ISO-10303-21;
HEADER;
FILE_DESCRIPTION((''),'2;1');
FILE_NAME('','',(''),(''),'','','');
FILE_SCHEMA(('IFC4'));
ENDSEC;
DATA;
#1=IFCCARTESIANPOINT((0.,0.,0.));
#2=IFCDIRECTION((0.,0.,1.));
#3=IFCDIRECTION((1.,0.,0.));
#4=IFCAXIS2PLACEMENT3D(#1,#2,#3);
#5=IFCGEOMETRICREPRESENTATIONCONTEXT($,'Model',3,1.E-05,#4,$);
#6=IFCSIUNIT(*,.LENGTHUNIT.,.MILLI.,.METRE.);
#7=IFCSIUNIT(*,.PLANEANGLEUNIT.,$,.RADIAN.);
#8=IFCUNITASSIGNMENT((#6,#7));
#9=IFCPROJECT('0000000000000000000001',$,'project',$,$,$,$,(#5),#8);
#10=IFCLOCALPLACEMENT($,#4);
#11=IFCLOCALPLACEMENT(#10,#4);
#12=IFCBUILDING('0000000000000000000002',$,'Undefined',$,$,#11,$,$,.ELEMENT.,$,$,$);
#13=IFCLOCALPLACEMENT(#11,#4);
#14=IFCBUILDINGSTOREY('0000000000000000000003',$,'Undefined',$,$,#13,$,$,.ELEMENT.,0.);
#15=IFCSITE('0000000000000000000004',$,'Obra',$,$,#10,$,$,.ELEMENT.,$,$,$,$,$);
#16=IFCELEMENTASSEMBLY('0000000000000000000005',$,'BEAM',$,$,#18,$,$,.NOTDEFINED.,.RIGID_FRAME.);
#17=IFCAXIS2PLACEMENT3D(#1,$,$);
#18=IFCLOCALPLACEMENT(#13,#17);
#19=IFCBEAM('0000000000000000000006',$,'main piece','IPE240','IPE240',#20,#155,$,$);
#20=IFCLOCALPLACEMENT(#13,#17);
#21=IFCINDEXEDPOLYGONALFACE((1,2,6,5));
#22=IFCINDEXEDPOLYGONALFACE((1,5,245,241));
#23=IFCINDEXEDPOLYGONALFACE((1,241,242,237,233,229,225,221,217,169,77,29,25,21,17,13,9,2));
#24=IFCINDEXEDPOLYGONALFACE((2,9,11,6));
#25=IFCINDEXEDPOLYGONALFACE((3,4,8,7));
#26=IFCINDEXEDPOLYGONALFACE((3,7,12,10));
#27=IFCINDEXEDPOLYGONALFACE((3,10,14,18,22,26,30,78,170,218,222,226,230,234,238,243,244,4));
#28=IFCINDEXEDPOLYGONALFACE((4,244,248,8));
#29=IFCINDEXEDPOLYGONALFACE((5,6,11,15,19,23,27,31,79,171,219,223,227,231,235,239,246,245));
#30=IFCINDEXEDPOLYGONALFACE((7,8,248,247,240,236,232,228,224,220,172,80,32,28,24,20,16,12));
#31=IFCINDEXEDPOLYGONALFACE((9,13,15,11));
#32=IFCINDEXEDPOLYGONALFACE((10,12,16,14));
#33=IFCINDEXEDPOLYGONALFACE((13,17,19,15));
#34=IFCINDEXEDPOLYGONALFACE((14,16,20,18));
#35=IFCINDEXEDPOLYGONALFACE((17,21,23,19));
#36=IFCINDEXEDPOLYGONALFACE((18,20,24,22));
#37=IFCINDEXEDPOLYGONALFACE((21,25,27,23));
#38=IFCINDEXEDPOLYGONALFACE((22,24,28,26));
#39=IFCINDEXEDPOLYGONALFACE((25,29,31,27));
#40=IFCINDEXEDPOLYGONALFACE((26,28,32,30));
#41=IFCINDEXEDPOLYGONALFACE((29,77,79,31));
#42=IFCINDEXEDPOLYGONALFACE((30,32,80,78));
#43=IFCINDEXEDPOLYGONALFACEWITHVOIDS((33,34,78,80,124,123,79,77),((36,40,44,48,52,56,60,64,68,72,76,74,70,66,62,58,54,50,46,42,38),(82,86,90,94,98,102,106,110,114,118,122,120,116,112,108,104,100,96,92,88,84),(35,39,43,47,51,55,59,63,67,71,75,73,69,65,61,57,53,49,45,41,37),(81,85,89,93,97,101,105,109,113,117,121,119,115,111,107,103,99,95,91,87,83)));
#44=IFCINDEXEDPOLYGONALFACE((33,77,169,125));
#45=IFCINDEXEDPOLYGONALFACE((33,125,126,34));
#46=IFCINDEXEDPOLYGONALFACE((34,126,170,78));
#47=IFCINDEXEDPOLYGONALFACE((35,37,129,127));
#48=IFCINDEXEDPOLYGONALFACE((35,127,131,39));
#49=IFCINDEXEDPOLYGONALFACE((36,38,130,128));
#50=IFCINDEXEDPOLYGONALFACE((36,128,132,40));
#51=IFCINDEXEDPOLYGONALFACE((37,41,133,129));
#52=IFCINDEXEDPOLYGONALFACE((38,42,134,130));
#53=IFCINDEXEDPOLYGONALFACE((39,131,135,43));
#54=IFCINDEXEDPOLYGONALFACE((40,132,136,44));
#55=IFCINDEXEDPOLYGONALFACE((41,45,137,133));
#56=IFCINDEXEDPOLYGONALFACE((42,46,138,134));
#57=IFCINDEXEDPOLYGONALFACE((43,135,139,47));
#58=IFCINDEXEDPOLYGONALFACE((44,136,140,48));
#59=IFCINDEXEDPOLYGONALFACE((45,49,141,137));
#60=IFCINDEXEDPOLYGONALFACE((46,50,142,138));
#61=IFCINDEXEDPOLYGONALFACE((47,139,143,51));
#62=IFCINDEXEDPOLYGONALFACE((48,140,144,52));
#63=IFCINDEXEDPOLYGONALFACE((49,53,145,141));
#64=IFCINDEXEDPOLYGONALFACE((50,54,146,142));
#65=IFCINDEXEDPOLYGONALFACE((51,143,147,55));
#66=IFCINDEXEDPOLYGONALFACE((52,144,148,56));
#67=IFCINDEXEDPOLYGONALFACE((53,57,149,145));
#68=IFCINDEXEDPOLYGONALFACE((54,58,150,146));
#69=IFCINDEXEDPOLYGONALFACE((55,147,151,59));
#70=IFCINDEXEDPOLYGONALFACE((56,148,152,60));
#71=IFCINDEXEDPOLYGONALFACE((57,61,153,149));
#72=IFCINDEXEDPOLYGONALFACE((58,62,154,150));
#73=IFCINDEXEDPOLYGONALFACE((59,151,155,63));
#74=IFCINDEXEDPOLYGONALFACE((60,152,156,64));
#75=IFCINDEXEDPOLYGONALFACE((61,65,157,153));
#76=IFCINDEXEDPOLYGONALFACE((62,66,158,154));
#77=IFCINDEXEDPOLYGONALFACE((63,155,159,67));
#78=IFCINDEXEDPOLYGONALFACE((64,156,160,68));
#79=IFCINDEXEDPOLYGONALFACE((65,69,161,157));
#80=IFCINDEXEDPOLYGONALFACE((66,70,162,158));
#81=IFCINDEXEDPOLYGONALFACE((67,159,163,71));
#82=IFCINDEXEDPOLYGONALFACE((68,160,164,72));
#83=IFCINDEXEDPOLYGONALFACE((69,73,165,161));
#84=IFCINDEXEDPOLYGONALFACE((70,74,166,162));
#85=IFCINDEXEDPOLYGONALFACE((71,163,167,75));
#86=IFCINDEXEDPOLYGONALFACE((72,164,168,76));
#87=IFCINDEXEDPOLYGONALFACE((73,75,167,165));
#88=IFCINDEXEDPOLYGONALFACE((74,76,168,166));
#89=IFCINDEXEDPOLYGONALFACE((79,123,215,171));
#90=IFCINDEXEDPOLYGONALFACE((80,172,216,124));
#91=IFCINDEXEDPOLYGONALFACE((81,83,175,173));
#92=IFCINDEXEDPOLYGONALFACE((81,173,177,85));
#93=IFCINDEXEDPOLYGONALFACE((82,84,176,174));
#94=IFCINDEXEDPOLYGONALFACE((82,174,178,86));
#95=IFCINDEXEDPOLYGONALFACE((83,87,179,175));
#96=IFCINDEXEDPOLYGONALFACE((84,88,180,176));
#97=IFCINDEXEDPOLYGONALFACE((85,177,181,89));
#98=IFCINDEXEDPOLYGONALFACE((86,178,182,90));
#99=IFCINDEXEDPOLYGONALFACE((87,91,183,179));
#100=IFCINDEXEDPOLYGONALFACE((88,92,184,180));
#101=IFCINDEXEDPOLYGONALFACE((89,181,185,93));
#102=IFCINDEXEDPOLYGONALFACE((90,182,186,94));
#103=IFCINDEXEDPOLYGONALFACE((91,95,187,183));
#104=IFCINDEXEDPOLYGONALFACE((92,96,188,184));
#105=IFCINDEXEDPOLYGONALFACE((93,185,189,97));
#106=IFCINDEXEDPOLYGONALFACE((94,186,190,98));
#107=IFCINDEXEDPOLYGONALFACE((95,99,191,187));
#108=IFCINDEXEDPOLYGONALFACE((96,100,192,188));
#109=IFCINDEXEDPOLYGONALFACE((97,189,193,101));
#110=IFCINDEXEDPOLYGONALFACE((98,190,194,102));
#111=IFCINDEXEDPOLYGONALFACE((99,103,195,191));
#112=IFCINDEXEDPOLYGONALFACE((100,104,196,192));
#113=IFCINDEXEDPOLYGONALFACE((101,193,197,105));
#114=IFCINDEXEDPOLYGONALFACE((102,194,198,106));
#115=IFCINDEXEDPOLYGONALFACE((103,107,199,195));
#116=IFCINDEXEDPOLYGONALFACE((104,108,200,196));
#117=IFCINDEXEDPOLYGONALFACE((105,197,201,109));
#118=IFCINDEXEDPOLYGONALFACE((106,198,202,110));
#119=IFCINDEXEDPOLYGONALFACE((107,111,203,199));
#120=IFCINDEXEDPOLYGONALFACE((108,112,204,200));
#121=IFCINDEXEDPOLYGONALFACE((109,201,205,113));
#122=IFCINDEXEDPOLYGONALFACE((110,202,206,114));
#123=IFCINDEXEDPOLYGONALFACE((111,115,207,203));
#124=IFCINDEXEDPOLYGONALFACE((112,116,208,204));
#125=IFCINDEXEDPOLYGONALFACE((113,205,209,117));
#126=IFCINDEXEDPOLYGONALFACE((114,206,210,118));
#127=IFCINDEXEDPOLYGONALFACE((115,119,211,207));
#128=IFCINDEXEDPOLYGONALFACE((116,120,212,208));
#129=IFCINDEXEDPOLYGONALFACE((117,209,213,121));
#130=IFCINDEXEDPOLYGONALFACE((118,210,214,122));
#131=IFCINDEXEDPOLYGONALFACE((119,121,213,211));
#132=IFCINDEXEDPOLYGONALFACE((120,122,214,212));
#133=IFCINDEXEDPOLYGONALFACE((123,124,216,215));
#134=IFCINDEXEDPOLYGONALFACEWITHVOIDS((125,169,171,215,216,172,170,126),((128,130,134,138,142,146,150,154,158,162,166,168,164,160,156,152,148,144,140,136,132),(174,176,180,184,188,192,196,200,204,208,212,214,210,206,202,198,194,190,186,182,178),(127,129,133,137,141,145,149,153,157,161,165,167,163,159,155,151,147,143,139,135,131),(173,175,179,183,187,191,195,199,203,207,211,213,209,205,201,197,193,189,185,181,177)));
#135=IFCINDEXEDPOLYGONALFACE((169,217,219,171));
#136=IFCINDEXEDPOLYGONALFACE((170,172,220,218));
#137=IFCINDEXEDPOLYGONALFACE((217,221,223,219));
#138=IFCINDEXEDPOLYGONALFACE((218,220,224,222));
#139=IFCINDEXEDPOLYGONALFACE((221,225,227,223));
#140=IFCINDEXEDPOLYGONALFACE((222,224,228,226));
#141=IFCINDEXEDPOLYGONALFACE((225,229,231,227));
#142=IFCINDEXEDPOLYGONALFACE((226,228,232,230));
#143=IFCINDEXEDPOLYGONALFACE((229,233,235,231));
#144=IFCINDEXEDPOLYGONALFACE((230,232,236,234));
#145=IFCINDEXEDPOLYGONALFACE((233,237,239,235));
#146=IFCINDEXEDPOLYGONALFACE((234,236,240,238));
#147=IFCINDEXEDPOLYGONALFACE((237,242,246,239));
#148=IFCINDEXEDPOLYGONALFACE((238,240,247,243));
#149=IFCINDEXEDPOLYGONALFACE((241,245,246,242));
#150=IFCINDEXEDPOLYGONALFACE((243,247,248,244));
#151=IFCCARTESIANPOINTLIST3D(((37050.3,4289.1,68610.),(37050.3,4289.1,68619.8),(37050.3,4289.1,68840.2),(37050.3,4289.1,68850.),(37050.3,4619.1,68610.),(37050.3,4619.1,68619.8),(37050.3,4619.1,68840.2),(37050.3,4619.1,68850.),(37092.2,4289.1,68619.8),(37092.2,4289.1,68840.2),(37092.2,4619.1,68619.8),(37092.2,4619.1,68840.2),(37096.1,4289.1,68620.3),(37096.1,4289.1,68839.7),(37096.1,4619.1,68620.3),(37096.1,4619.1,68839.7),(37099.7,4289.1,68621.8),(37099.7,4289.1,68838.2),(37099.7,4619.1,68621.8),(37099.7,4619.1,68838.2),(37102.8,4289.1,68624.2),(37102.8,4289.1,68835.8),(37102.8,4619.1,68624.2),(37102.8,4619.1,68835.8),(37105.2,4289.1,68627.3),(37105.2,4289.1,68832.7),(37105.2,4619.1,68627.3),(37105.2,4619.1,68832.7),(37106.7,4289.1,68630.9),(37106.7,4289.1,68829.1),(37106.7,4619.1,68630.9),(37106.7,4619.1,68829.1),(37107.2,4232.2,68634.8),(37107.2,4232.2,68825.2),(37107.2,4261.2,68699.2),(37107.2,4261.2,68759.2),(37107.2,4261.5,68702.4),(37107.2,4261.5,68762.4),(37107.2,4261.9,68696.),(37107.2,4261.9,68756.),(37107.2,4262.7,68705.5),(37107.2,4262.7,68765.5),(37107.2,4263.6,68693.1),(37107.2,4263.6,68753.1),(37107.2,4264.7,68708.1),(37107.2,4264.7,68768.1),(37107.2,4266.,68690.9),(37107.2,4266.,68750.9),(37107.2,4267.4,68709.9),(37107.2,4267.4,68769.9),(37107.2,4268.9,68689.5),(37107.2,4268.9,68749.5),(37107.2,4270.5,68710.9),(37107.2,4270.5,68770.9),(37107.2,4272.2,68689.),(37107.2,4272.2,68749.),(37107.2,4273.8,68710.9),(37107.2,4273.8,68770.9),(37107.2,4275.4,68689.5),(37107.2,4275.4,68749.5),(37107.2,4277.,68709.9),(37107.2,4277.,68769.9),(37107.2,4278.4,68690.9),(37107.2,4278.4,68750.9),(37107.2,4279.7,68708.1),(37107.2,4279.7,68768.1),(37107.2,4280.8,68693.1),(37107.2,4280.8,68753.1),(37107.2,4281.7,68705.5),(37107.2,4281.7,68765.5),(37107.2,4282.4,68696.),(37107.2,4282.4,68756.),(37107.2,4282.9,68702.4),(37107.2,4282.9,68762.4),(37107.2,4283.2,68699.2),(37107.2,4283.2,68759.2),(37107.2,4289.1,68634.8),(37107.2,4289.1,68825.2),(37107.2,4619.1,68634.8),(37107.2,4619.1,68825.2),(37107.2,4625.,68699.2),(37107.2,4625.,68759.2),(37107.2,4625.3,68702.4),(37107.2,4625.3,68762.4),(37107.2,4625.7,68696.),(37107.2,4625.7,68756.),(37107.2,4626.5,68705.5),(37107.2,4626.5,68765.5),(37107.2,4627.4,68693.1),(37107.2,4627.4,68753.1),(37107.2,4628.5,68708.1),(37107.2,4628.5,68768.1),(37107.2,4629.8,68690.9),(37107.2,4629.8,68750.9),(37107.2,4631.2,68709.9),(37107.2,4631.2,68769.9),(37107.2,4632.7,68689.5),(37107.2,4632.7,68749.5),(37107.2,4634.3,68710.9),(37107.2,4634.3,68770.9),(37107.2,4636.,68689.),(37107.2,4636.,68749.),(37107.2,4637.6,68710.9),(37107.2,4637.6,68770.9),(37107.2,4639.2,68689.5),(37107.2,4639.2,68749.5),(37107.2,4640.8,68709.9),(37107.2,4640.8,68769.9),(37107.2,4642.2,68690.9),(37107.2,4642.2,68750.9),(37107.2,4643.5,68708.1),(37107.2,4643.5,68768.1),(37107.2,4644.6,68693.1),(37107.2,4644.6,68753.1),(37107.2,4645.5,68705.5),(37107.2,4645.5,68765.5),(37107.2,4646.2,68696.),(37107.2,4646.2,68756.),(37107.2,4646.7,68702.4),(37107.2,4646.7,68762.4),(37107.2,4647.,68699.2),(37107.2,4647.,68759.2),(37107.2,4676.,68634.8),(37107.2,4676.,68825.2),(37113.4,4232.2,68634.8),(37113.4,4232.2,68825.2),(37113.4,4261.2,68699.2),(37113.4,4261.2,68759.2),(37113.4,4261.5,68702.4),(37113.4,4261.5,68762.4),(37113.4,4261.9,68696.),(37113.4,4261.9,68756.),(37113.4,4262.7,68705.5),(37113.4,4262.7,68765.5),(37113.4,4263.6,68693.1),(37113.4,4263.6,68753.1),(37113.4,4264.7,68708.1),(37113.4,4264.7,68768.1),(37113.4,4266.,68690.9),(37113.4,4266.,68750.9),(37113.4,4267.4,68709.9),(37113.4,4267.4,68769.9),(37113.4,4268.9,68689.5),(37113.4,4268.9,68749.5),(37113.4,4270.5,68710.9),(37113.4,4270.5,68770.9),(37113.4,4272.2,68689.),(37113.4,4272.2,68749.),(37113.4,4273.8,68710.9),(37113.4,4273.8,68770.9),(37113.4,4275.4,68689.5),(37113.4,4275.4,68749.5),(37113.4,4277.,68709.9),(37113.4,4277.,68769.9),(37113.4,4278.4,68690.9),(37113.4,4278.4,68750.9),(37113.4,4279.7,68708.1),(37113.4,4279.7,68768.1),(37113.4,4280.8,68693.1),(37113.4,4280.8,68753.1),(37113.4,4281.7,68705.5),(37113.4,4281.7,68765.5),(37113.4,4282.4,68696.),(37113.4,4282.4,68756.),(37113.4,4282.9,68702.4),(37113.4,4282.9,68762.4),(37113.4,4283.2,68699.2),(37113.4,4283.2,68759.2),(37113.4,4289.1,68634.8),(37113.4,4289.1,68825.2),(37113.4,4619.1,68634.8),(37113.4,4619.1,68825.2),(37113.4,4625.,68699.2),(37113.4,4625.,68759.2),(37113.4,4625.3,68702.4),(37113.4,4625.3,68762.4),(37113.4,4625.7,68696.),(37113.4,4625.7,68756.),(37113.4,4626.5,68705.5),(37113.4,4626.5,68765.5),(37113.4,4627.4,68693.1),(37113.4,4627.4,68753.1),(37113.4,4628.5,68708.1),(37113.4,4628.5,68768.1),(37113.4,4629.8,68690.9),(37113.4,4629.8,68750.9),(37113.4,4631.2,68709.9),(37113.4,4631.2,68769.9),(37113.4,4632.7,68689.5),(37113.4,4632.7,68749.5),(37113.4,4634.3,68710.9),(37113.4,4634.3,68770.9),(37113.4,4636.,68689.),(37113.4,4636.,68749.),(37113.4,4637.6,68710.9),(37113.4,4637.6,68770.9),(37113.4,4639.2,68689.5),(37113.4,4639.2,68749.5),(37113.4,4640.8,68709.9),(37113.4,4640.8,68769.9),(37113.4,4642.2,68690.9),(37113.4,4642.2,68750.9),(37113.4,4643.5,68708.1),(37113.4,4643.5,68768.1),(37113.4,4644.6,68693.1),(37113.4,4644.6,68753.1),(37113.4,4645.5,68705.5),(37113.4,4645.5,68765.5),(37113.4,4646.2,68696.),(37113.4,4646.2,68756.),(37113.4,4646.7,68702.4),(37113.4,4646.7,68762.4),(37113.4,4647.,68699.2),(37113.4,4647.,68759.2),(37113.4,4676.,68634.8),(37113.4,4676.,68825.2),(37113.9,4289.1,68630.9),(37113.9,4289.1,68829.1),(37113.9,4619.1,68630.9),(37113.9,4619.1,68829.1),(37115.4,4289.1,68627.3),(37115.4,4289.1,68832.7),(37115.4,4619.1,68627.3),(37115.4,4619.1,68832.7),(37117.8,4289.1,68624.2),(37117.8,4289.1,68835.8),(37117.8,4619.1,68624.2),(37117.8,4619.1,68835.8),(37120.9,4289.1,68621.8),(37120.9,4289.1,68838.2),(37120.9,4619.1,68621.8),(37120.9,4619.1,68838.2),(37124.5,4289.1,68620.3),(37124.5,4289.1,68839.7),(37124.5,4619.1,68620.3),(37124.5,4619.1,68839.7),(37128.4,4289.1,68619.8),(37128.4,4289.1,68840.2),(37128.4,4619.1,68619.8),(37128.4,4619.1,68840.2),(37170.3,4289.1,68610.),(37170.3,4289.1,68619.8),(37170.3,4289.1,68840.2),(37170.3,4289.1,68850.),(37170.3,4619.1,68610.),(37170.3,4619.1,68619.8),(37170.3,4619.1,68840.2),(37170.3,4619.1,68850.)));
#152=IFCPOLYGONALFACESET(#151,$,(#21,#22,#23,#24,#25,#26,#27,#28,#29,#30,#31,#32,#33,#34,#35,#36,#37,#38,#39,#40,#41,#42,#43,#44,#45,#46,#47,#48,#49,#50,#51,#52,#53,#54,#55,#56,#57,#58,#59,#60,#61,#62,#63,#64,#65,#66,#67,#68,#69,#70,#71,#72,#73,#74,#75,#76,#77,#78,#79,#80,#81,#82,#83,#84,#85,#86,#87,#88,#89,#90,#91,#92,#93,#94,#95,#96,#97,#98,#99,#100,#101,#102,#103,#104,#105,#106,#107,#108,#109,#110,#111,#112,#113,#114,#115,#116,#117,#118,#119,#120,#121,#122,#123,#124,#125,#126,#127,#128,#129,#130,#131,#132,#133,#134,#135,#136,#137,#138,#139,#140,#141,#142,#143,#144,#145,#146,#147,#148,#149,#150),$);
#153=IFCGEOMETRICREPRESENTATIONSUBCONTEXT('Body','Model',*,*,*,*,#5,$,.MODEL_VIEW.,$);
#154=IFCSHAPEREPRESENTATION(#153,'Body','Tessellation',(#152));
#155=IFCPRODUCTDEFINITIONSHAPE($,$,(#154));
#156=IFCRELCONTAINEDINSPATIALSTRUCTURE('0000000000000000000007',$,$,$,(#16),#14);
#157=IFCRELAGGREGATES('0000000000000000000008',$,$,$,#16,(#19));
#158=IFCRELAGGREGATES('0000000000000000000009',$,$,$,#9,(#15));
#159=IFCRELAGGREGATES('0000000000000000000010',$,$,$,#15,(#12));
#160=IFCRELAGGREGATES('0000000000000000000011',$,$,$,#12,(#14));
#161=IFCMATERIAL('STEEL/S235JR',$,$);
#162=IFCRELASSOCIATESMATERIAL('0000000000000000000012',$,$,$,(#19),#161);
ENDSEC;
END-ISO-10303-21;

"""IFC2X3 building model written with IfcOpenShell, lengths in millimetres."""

from ifc_helpers import new_model, si_unit, frame, origin_with_axes, origin_2d_with_axis, place, context, subcontext, project, spatial, rectangle, circle, i_section, extrude, clip, halfspace, source, transform, mapped, material, element, aggregate, save


model = new_model("IFC2X3")

# Units and contexts
model_context = context("Model", 3, precision=1e-05, world=origin_with_axes())
body_context = subcontext(model_context, "Body", "Model", "MODEL_VIEW")
ifc_project = project(units=[si_unit("LENGTHUNIT", "METRE", prefix="MILLI"), si_unit("PLANEANGLEUNIT", "RADIAN")], contexts=[model_context])

# Site, building, storey
site_placement = place(None, origin_with_axes())
site = spatial("IfcSite", under=ifc_project, at=site_placement, Name="Obra", CompositionType="ELEMENT")
building_placement = place(site_placement, origin_with_axes())
building = spatial("IfcBuilding", under=site, at=building_placement, Name="Undefined", CompositionType="ELEMENT")
storey_placement = place(building_placement, origin_with_axes())
storey = spatial("IfcBuildingStorey", under=building, at=storey_placement, Name="Undefined", CompositionType="ELEMENT", Elevation=0.0)

# Element assembly, beam, openings
assembly_1_placement = place(storey_placement, origin_with_axes())
assembly_1 = element("IfcElementAssembly", 1, at=assembly_1_placement, inside=storey, Name="BEAM", AssemblyPlace="NOTDEFINED", PredefinedType="RIGID_FRAME")
ifc_material_1 = material(Name="STEEL/S235JR")
beam_1_placement = place(assembly_1_placement, frame((37110.3, 4299.1, 68730.0), z_axis=(0.0, 0.0, 1.0), x_axis=(0.0, 1.0, 0.0)))
beam_1 = element("IfcBeam", 2, at=beam_1_placement, material=ifc_material_1, Name="main piece", Description="IPE240", ObjectType="IPE240", context=body_context, shape_type="Clipping", body=[
    clip(clip(extrude(i_section(OverallWidth=120.0, OverallDepth=240.0, WebThickness=6.2, FlangeThickness=9.8, FilletRadius=15.0, at=origin_2d_with_axis()), frame((376.9, 0.0, 0.0), z_axis=(-1.0, 0.0, 0.0), x_axis=(0.0, -1.0, 0.0)), (0.0, 0.0, 1.0), 443.8), halfspace(frame((376.9, 0.0, -220.0), z_axis=(-1.0, 0.0, 0.0), x_axis=(0.0, 1.0, 0.0)), True)), halfspace(frame((-66.9, 0.0, -220.0), z_axis=(1.0, 0.0, 0.0), x_axis=(0.0, -1.0, 0.0)), True)),
])
opening_1_placement = place(assembly_1_placement, frame((37110.3, 4299.1, 68730.0), z_axis=(0.0, 0.0, 1.0), x_axis=(0.0, 1.0, 0.0)))
element("IfcOpeningElement", 3, at=opening_1_placement, cuts=beam_1, ObjectType="Recess", context=body_context, shape_type="SweptSolid", body=[
    extrude(rectangle(XDim=25.8, YDim=68.9, at=origin_2d_with_axis()), frame((354.4, 61.0, -108.1), z_axis=(0.0, -1.0, 0.0), x_axis=(0.0, 0.0, -1.0)), (0.0, 0.0, 1.0), 122.0),
])
opening_2_placement = place(assembly_1_placement, frame((37110.3, 4299.1, 68730.0), z_axis=(0.0, 0.0, 1.0), x_axis=(0.0, 1.0, 0.0)))
element("IfcOpeningElement", 4, at=opening_2_placement, cuts=beam_1, ObjectType="Recess", context=body_context, shape_type="SweptSolid", body=[
    extrude(rectangle(XDim=25.8, YDim=68.9, at=origin_2d_with_axis()), frame((354.4, 61.0, 108.1), z_axis=(0.0, -1.0, 0.0), x_axis=(0.0, 0.0, -1.0)), (0.0, 0.0, 1.0), 122.0),
])
opening_3_placement = place(assembly_1_placement, frame((37110.3, 4299.1, 68730.0), z_axis=(0.0, 0.0, 1.0), x_axis=(0.0, 1.0, 0.0)))
element("IfcOpeningElement", 5, at=opening_3_placement, cuts=beam_1, ObjectType="Recess", context=body_context, shape_type="SweptSolid", body=[
    extrude(rectangle(XDim=25.8, YDim=68.9, at=origin_2d_with_axis()), frame((-44.4, -61.0, -108.1), z_axis=(0.0, 1.0, 0.0), x_axis=(0.0, 0.0, -1.0)), (0.0, 0.0, 1.0), 122.0),
])
opening_4_placement = place(assembly_1_placement, frame((37110.3, 4299.1, 68730.0), z_axis=(0.0, 0.0, 1.0), x_axis=(0.0, 1.0, 0.0)))
element("IfcOpeningElement", 6, at=opening_4_placement, cuts=beam_1, ObjectType="Recess", context=body_context, shape_type="SweptSolid", body=[
    extrude(rectangle(XDim=25.8, YDim=68.9, at=origin_2d_with_axis()), frame((-44.4, -61.0, 108.1), z_axis=(0.0, 1.0, 0.0), x_axis=(0.0, 0.0, -1.0)), (0.0, 0.0, 1.0), 122.0),
])
shared_shape_1 = source(origin_with_axes(), body_context, "Body", "SweptSolid", [
    extrude(circle(Radius=11.0, at=origin_2d_with_axis()), frame((0.0, -3.2, 0.0), z_axis=(0.0, 1.0, 0.0), x_axis=(1.0, 0.0, 0.0)), (0.0, 0.0, 1.0), 6.4),
])
opening_5_placement = place(assembly_1_placement, frame((37110.3, 4676.0, 68850.0), z_axis=(0.0, -1.0, 0.0), x_axis=(0.0, 0.0, -1.0)))
element("IfcOpeningElement", 7, at=opening_5_placement, cuts=beam_1, ObjectType="Opening", context=body_context, shape_type="MappedRepresentation", body=[
    mapped(shared_shape_1, transform((90.0, 0.0, 40.0))),
    mapped(shared_shape_1, transform((150.0, 0.0, 40.0))),
])
opening_6_placement = place(assembly_1_placement, frame((37110.3, 4232.2, 68850.0), z_axis=(0.0, 1.0, 0.0), x_axis=(0.0, 0.0, -1.0)))
element("IfcOpeningElement", 8, at=opening_6_placement, cuts=beam_1, ObjectType="Opening", context=body_context, shape_type="MappedRepresentation", body=[
    mapped(shared_shape_1, transform((90.0, 0.0, 40.0))),
    mapped(shared_shape_1, transform((150.0, 0.0, 40.0))),
])
aggregate(assembly_1, [beam_1])

save(model, "model.ifc")
